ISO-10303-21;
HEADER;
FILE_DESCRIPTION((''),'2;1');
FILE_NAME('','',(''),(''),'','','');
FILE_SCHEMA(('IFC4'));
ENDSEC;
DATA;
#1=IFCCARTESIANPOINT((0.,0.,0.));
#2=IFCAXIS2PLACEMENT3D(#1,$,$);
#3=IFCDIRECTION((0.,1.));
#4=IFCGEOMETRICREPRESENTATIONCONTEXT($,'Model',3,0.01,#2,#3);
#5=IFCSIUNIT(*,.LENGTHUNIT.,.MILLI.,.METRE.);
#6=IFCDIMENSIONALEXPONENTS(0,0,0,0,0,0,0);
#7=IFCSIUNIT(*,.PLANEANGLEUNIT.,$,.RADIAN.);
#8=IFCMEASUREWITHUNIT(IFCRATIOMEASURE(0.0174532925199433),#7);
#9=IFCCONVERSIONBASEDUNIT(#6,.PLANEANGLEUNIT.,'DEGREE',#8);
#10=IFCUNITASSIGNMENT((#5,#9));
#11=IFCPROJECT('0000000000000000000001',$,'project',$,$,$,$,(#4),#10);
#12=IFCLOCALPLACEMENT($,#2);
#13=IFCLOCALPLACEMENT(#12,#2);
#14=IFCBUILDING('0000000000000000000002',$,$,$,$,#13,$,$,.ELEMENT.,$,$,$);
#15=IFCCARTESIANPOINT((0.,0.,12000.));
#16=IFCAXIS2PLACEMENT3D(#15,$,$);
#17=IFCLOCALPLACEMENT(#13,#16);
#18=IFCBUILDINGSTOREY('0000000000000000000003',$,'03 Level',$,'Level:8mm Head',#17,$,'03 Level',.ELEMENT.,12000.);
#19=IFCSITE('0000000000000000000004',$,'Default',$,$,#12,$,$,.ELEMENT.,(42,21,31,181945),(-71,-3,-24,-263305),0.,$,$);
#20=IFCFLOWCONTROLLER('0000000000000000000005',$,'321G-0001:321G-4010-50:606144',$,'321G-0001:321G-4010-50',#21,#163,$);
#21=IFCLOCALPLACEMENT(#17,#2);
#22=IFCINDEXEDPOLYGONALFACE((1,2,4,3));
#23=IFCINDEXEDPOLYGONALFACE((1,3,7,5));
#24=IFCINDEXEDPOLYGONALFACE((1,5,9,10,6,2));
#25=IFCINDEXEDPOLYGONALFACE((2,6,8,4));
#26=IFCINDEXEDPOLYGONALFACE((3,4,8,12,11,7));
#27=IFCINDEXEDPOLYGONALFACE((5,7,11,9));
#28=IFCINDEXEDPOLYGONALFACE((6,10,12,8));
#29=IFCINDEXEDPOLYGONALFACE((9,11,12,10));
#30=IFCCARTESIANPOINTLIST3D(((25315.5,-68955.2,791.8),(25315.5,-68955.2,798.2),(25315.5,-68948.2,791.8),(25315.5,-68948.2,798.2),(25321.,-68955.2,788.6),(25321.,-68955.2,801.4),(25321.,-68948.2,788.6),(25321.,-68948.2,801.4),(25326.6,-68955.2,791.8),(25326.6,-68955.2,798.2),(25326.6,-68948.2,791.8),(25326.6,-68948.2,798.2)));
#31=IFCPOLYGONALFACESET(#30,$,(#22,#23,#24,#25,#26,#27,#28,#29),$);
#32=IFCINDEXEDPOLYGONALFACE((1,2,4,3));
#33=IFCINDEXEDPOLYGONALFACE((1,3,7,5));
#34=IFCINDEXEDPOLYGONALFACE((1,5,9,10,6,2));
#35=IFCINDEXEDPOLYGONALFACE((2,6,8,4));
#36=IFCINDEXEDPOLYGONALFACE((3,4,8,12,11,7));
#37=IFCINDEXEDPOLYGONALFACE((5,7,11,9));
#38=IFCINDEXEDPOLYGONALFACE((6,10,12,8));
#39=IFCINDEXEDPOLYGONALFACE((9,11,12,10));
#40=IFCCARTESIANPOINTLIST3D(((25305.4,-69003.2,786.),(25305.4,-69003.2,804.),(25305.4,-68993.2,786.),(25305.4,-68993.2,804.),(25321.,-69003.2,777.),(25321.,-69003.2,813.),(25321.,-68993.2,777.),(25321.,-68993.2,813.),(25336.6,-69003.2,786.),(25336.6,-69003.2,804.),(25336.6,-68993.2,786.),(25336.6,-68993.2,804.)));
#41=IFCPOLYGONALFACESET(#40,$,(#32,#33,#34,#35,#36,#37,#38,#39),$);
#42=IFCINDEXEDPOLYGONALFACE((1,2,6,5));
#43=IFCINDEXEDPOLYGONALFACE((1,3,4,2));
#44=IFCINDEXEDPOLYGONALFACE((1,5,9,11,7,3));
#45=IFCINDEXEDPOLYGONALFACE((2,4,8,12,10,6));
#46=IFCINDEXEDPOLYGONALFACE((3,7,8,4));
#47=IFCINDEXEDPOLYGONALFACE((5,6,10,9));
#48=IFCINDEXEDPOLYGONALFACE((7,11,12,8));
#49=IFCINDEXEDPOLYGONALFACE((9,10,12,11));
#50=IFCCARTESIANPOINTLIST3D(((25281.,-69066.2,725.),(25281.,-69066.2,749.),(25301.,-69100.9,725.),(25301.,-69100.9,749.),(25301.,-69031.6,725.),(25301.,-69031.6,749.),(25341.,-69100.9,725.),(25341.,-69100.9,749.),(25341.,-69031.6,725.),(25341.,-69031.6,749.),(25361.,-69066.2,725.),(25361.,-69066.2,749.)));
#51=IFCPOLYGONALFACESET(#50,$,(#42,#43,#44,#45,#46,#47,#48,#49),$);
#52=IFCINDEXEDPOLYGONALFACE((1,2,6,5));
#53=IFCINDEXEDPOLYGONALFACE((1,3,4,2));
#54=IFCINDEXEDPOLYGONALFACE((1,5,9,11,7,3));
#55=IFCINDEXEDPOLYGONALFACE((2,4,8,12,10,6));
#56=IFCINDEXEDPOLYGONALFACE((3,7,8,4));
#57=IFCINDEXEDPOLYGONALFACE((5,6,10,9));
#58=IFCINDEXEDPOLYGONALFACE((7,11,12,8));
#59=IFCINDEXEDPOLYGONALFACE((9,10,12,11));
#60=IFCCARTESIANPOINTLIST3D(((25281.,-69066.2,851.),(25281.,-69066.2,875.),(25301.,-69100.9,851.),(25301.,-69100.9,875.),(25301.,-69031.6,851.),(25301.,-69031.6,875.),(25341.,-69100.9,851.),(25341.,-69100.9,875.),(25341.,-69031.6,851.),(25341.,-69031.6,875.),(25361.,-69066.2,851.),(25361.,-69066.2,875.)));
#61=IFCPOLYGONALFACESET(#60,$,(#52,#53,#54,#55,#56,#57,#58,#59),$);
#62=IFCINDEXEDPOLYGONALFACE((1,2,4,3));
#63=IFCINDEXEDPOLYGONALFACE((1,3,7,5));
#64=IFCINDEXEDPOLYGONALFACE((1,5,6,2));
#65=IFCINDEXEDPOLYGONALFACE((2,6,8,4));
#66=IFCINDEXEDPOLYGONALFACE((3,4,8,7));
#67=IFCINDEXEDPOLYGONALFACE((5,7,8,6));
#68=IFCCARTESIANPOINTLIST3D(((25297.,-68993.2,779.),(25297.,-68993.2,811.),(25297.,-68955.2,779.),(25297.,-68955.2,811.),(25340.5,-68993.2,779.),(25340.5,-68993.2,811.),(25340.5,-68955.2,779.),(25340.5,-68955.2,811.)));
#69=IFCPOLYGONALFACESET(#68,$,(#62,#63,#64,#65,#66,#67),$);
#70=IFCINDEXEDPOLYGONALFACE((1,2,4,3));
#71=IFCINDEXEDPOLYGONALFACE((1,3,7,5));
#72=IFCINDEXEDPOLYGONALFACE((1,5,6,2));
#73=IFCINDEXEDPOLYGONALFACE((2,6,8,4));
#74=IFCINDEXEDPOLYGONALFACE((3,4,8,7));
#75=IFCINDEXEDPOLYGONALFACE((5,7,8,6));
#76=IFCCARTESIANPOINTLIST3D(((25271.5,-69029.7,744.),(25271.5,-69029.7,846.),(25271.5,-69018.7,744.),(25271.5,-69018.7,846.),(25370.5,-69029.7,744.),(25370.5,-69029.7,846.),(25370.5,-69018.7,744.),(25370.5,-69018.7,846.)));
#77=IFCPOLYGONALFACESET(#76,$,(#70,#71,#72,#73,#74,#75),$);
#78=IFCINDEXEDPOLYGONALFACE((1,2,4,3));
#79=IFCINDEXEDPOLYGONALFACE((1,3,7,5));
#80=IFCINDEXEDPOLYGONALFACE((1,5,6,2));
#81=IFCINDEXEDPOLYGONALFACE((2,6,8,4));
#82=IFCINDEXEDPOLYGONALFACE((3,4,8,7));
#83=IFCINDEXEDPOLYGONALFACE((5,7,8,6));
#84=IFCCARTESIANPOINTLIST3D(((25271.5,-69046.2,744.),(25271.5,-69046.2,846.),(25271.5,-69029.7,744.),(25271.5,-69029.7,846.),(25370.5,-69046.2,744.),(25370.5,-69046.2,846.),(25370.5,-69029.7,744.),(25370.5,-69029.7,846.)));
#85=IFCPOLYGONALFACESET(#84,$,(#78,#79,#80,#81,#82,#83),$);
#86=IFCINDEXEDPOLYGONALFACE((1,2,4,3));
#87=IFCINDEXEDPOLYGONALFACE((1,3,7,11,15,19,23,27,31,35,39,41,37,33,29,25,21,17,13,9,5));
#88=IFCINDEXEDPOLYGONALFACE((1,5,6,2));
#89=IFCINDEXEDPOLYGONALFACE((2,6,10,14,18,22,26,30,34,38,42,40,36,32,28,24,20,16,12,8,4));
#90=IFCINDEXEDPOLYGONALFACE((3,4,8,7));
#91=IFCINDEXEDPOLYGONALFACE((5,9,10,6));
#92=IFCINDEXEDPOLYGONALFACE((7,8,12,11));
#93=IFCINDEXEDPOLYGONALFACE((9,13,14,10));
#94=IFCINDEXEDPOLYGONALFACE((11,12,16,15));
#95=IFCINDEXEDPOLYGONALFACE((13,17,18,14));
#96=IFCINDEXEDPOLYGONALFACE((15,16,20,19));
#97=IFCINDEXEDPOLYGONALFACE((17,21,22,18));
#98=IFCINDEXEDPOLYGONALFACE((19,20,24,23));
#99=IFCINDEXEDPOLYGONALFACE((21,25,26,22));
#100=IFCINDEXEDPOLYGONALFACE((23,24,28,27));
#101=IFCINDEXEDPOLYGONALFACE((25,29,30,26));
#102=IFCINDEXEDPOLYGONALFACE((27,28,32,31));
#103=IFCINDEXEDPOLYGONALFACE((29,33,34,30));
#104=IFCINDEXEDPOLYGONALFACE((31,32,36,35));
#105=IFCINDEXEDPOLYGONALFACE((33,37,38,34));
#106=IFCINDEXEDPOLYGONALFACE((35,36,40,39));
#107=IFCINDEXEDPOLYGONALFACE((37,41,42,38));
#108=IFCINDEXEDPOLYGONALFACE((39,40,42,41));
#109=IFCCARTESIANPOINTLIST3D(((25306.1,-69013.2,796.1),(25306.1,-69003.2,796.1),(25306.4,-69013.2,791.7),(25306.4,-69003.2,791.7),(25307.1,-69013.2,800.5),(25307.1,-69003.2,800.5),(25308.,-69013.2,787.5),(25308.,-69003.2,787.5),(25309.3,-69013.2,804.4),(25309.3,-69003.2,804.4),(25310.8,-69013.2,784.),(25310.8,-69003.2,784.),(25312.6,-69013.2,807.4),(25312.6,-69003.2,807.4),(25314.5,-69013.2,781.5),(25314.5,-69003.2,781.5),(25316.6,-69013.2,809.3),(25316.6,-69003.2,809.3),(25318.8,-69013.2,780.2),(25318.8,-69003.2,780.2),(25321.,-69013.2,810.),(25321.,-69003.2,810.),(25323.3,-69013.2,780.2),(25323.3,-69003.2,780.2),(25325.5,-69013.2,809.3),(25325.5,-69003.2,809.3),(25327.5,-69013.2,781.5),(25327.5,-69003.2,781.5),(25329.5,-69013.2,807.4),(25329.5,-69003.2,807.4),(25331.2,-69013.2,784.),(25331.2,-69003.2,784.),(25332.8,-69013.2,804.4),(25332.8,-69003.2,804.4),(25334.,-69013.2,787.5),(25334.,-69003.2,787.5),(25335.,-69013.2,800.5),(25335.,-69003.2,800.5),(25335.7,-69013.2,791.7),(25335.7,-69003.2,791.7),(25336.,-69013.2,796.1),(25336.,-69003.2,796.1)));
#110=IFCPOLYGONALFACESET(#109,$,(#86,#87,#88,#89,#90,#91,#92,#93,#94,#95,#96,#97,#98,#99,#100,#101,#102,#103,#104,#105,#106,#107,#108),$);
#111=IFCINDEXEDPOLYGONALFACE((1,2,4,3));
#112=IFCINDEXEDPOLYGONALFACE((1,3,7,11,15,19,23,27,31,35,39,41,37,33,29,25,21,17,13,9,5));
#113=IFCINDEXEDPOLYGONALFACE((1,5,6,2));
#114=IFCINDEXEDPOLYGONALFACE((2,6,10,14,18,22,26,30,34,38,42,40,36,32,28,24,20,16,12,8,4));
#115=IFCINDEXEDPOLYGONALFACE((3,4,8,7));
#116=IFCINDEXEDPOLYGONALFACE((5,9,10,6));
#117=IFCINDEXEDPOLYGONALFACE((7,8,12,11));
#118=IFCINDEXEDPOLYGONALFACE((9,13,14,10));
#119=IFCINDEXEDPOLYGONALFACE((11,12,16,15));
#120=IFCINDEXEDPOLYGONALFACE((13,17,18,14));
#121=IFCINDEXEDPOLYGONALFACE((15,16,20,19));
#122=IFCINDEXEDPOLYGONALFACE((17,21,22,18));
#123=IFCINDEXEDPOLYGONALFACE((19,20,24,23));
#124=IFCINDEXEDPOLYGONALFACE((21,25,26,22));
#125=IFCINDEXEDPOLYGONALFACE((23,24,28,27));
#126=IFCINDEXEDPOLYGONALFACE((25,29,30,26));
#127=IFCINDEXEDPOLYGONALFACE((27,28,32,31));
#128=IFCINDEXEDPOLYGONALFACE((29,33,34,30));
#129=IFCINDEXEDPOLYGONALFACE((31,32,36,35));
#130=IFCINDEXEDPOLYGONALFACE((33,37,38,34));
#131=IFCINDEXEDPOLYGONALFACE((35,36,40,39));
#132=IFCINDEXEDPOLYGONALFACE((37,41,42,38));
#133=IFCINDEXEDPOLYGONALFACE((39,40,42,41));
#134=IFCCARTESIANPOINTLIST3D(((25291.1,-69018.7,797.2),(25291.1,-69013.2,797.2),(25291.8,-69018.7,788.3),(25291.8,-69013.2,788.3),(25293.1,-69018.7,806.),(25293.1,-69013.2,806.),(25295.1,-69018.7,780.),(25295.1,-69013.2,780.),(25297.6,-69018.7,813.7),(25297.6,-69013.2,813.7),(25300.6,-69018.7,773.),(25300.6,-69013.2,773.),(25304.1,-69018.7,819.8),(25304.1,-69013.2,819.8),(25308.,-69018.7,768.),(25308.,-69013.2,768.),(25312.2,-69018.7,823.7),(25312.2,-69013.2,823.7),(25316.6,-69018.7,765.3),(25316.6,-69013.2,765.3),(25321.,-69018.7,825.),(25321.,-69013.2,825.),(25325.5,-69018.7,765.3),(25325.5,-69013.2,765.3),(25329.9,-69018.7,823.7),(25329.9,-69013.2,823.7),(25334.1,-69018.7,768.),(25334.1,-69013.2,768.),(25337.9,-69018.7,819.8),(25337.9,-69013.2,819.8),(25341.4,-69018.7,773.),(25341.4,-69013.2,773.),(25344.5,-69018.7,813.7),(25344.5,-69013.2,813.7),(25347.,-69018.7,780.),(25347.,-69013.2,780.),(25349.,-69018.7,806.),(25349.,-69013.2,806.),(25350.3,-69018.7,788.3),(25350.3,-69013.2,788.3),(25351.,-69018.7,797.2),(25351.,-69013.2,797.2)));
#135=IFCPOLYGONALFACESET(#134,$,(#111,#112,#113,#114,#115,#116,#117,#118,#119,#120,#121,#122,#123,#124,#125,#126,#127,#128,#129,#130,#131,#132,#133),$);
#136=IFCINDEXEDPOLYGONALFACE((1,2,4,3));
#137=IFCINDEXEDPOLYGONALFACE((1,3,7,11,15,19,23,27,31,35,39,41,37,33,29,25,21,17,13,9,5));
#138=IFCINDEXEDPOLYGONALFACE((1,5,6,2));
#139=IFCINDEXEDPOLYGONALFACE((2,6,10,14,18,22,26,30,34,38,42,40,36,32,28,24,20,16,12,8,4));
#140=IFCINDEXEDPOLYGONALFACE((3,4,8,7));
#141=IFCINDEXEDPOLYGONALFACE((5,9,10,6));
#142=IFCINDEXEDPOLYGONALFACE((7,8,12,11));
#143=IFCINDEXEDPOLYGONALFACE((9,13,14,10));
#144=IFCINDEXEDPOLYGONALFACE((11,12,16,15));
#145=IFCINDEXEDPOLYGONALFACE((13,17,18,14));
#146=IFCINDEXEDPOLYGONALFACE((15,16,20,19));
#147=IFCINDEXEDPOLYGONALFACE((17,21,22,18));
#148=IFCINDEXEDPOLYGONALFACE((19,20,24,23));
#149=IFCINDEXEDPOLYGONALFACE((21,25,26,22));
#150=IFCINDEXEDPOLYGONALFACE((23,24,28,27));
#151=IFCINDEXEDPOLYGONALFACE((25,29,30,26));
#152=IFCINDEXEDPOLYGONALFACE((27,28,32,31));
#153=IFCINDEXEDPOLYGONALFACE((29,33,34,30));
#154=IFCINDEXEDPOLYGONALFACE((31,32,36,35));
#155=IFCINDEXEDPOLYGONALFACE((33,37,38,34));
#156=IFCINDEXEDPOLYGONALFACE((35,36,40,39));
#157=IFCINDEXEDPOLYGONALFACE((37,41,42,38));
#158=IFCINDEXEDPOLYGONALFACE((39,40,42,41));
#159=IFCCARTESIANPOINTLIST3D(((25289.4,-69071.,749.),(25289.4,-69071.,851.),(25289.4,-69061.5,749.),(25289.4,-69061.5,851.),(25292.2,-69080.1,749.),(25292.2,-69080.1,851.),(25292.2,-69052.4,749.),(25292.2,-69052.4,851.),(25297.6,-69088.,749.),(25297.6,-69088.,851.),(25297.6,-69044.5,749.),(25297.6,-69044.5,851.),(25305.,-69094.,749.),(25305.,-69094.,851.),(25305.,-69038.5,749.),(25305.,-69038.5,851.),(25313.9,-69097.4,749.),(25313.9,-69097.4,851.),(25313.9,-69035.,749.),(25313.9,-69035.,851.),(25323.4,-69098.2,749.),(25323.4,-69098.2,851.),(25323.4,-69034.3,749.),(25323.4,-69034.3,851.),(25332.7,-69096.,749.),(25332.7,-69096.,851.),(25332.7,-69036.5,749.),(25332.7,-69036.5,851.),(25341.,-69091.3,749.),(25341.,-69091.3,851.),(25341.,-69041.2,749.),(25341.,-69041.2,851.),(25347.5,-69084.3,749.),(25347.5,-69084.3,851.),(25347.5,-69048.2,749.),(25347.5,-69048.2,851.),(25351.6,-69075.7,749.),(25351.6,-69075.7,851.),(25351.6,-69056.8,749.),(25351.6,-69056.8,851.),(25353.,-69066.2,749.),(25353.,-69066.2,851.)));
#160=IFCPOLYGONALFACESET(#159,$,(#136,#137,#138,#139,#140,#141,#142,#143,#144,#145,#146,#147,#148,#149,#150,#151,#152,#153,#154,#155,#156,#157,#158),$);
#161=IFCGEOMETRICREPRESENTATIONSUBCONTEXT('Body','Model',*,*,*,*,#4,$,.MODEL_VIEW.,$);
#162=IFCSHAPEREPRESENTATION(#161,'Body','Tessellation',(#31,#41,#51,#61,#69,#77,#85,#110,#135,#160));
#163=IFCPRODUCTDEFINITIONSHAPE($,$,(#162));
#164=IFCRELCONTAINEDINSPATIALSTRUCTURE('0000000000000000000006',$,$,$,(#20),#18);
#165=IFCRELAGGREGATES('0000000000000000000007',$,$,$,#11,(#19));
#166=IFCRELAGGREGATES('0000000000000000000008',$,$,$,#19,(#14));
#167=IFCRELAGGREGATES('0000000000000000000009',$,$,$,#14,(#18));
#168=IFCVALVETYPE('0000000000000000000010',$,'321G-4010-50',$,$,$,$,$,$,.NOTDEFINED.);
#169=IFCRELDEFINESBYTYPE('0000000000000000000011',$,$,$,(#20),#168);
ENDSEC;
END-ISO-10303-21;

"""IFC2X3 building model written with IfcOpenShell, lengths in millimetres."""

from ifc_helpers import new_model, entity, si_unit, converted_unit, direction, frame, frame_2d, origin, origin_2d_with_axis, place, context, subcontext, project, spatial, polyline, rectangle, circle, outline, extrude, source, transform, mapped, type_object, type_shapes, element, save


model = new_model("IFC2X3")

# Units and contexts
model_context = context("Model", 3, precision=0.01, world=origin(), true_north=direction((0.0, 1.0)))
body_context = subcontext(model_context, "Body", "Model", "MODEL_VIEW")
ifc_project = project(units=[si_unit("LENGTHUNIT", "METRE", prefix="MILLI"), converted_unit("PLANEANGLEUNIT", "DEGREE", entity("IfcRatioMeasure", 0.0174532925199433), si_unit("PLANEANGLEUNIT", "RADIAN"), dimensions=[0, 0, 0, 0, 0, 0, 0])], contexts=[model_context])

# Site, building, storey
site_placement = place(None, origin())
site = spatial("IfcSite", under=ifc_project, at=site_placement, Name="Default", CompositionType="ELEMENT", RefLatitude=(42, 21, 31, 181945), RefLongitude=(-71, -3, -24, -263305), RefElevation=0.0)
building_placement = place(site_placement, origin())
building = spatial("IfcBuilding", under=site, at=building_placement, CompositionType="ELEMENT")
storey_placement = place(building_placement, frame((0.0, 0.0, 12000.0)))
storey = spatial("IfcBuildingStorey", under=building, at=storey_placement, Name="03 Level", ObjectType="Level:8mm Head", LongName="03 Level", CompositionType="ELEMENT", Elevation=12000.0)

# Flow controller
valve_type_1 = type_object("IfcValveType", Name="321G-4010-50", PredefinedType="NOTDEFINED")
shared_shape_1 = source(origin(), body_context, "Body", "SweptSolid", [
    extrude(outline(polyline([(-3.2, -5.5), (3.2, -5.5), (6.4, 0.0), (3.2, 5.5), (-3.2, 5.5), (-6.4, 0.0), (-3.2, -5.5)])), frame((-5.0, 0.0, 111.0), z_axis=(0.0, 0.0, 1.0), x_axis=(-1.0, 0.0, 0.0)), (0.0, 0.0, 1.0), 7.0),
    extrude(outline(polyline([(-9.0, -15.6), (9.0, -15.6), (18.0, 0.0), (9.0, 15.6), (-9.0, 15.6), (-18.0, 0.0), (-9.0, -15.6)])), frame((-5.0, 0.0, 63.0), z_axis=(0.0, 0.0, 1.0), x_axis=(-1.0, 0.0, 0.0)), (0.0, 0.0, 1.0), 10.0),
    extrude(outline(polyline([(-20.0, -34.6), (20.0, -34.6), (40.0, 0.0), (20.0, 34.6), (-20.0, 34.6), (-40.0, 0.0), (-20.0, -34.6)])), frame((-75.0, 0.0, 0.0), z_axis=(1.0, 0.0, 0.0), x_axis=(0.0, -1.0, 0.0)), (0.0, 0.0, 1.0), 24.0),
    extrude(outline(polyline([(-20.0, -34.6), (20.0, -34.6), (40.0, 0.0), (20.0, 34.6), (-20.0, 34.6), (-40.0, 0.0), (-20.0, -34.6)])), frame((51.0, 0.0, 0.0), z_axis=(1.0, 0.0, 0.0), x_axis=(0.0, -1.0, 0.0)), (0.0, 0.0, 1.0), 24.0),
    extrude(rectangle(XDim=32.0, YDim=43.5, at=origin_2d_with_axis()), frame((-5.0, -2.2, 73.0)), (0.0, 0.0, 1.0), 38.0),
    extrude(rectangle(XDim=102.0, YDim=99.0, at=origin_2d_with_axis()), frame((-5.0, 0.0, 36.5)), (0.0, 0.0, 1.0), 11.0),
    extrude(rectangle(XDim=102.0, YDim=99.0, at=origin_2d_with_axis()), frame((-5.0, 0.0, 20.0)), (0.0, 0.0, 1.0), 16.5),
    extrude(circle(Radius=15.0, at=frame_2d((0.0, 0.0), x_axis=(1.0, 0.0))), frame((-5.0, 0.0, 53.0)), (0.0, 0.0, 1.0), 10.0),
    extrude(circle(Radius=30.0, at=frame_2d((0.0, 0.0), x_axis=(1.0, 0.0))), frame((-5.0, 0.0, 47.5)), (0.0, 0.0, 1.0), 5.5),
    extrude(circle(Radius=32.0, at=frame_2d((0.0, 0.0), x_axis=(1.0, 0.0))), frame((-51.0, 0.0, 0.0), z_axis=(1.0, 0.0, 0.0), x_axis=(0.0, 1.0, 0.0)), (0.0, 0.0, 1.0), 102.0),
])
type_shapes(valve_type_1, [shared_shape_1])
flow_controller_1_placement = place(storey_placement, frame((25321.0, -69066.2, 800.0), z_axis=(0.0, 1.0, 0.0), x_axis=(0.0, 0.0, 1.0)))
element("IfcFlowController", 1, at=flow_controller_1_placement, inside=storey, type_object=valve_type_1, Name="321G-0001:321G-4010-50:606144", ObjectType="321G-0001:321G-4010-50", context=body_context, shape_type="MappedRepresentation", body=[
    mapped(shared_shape_1, transform((0.0, 0.0, 0.0), scale=1.0)),
])

save(model, "model.ifc")
